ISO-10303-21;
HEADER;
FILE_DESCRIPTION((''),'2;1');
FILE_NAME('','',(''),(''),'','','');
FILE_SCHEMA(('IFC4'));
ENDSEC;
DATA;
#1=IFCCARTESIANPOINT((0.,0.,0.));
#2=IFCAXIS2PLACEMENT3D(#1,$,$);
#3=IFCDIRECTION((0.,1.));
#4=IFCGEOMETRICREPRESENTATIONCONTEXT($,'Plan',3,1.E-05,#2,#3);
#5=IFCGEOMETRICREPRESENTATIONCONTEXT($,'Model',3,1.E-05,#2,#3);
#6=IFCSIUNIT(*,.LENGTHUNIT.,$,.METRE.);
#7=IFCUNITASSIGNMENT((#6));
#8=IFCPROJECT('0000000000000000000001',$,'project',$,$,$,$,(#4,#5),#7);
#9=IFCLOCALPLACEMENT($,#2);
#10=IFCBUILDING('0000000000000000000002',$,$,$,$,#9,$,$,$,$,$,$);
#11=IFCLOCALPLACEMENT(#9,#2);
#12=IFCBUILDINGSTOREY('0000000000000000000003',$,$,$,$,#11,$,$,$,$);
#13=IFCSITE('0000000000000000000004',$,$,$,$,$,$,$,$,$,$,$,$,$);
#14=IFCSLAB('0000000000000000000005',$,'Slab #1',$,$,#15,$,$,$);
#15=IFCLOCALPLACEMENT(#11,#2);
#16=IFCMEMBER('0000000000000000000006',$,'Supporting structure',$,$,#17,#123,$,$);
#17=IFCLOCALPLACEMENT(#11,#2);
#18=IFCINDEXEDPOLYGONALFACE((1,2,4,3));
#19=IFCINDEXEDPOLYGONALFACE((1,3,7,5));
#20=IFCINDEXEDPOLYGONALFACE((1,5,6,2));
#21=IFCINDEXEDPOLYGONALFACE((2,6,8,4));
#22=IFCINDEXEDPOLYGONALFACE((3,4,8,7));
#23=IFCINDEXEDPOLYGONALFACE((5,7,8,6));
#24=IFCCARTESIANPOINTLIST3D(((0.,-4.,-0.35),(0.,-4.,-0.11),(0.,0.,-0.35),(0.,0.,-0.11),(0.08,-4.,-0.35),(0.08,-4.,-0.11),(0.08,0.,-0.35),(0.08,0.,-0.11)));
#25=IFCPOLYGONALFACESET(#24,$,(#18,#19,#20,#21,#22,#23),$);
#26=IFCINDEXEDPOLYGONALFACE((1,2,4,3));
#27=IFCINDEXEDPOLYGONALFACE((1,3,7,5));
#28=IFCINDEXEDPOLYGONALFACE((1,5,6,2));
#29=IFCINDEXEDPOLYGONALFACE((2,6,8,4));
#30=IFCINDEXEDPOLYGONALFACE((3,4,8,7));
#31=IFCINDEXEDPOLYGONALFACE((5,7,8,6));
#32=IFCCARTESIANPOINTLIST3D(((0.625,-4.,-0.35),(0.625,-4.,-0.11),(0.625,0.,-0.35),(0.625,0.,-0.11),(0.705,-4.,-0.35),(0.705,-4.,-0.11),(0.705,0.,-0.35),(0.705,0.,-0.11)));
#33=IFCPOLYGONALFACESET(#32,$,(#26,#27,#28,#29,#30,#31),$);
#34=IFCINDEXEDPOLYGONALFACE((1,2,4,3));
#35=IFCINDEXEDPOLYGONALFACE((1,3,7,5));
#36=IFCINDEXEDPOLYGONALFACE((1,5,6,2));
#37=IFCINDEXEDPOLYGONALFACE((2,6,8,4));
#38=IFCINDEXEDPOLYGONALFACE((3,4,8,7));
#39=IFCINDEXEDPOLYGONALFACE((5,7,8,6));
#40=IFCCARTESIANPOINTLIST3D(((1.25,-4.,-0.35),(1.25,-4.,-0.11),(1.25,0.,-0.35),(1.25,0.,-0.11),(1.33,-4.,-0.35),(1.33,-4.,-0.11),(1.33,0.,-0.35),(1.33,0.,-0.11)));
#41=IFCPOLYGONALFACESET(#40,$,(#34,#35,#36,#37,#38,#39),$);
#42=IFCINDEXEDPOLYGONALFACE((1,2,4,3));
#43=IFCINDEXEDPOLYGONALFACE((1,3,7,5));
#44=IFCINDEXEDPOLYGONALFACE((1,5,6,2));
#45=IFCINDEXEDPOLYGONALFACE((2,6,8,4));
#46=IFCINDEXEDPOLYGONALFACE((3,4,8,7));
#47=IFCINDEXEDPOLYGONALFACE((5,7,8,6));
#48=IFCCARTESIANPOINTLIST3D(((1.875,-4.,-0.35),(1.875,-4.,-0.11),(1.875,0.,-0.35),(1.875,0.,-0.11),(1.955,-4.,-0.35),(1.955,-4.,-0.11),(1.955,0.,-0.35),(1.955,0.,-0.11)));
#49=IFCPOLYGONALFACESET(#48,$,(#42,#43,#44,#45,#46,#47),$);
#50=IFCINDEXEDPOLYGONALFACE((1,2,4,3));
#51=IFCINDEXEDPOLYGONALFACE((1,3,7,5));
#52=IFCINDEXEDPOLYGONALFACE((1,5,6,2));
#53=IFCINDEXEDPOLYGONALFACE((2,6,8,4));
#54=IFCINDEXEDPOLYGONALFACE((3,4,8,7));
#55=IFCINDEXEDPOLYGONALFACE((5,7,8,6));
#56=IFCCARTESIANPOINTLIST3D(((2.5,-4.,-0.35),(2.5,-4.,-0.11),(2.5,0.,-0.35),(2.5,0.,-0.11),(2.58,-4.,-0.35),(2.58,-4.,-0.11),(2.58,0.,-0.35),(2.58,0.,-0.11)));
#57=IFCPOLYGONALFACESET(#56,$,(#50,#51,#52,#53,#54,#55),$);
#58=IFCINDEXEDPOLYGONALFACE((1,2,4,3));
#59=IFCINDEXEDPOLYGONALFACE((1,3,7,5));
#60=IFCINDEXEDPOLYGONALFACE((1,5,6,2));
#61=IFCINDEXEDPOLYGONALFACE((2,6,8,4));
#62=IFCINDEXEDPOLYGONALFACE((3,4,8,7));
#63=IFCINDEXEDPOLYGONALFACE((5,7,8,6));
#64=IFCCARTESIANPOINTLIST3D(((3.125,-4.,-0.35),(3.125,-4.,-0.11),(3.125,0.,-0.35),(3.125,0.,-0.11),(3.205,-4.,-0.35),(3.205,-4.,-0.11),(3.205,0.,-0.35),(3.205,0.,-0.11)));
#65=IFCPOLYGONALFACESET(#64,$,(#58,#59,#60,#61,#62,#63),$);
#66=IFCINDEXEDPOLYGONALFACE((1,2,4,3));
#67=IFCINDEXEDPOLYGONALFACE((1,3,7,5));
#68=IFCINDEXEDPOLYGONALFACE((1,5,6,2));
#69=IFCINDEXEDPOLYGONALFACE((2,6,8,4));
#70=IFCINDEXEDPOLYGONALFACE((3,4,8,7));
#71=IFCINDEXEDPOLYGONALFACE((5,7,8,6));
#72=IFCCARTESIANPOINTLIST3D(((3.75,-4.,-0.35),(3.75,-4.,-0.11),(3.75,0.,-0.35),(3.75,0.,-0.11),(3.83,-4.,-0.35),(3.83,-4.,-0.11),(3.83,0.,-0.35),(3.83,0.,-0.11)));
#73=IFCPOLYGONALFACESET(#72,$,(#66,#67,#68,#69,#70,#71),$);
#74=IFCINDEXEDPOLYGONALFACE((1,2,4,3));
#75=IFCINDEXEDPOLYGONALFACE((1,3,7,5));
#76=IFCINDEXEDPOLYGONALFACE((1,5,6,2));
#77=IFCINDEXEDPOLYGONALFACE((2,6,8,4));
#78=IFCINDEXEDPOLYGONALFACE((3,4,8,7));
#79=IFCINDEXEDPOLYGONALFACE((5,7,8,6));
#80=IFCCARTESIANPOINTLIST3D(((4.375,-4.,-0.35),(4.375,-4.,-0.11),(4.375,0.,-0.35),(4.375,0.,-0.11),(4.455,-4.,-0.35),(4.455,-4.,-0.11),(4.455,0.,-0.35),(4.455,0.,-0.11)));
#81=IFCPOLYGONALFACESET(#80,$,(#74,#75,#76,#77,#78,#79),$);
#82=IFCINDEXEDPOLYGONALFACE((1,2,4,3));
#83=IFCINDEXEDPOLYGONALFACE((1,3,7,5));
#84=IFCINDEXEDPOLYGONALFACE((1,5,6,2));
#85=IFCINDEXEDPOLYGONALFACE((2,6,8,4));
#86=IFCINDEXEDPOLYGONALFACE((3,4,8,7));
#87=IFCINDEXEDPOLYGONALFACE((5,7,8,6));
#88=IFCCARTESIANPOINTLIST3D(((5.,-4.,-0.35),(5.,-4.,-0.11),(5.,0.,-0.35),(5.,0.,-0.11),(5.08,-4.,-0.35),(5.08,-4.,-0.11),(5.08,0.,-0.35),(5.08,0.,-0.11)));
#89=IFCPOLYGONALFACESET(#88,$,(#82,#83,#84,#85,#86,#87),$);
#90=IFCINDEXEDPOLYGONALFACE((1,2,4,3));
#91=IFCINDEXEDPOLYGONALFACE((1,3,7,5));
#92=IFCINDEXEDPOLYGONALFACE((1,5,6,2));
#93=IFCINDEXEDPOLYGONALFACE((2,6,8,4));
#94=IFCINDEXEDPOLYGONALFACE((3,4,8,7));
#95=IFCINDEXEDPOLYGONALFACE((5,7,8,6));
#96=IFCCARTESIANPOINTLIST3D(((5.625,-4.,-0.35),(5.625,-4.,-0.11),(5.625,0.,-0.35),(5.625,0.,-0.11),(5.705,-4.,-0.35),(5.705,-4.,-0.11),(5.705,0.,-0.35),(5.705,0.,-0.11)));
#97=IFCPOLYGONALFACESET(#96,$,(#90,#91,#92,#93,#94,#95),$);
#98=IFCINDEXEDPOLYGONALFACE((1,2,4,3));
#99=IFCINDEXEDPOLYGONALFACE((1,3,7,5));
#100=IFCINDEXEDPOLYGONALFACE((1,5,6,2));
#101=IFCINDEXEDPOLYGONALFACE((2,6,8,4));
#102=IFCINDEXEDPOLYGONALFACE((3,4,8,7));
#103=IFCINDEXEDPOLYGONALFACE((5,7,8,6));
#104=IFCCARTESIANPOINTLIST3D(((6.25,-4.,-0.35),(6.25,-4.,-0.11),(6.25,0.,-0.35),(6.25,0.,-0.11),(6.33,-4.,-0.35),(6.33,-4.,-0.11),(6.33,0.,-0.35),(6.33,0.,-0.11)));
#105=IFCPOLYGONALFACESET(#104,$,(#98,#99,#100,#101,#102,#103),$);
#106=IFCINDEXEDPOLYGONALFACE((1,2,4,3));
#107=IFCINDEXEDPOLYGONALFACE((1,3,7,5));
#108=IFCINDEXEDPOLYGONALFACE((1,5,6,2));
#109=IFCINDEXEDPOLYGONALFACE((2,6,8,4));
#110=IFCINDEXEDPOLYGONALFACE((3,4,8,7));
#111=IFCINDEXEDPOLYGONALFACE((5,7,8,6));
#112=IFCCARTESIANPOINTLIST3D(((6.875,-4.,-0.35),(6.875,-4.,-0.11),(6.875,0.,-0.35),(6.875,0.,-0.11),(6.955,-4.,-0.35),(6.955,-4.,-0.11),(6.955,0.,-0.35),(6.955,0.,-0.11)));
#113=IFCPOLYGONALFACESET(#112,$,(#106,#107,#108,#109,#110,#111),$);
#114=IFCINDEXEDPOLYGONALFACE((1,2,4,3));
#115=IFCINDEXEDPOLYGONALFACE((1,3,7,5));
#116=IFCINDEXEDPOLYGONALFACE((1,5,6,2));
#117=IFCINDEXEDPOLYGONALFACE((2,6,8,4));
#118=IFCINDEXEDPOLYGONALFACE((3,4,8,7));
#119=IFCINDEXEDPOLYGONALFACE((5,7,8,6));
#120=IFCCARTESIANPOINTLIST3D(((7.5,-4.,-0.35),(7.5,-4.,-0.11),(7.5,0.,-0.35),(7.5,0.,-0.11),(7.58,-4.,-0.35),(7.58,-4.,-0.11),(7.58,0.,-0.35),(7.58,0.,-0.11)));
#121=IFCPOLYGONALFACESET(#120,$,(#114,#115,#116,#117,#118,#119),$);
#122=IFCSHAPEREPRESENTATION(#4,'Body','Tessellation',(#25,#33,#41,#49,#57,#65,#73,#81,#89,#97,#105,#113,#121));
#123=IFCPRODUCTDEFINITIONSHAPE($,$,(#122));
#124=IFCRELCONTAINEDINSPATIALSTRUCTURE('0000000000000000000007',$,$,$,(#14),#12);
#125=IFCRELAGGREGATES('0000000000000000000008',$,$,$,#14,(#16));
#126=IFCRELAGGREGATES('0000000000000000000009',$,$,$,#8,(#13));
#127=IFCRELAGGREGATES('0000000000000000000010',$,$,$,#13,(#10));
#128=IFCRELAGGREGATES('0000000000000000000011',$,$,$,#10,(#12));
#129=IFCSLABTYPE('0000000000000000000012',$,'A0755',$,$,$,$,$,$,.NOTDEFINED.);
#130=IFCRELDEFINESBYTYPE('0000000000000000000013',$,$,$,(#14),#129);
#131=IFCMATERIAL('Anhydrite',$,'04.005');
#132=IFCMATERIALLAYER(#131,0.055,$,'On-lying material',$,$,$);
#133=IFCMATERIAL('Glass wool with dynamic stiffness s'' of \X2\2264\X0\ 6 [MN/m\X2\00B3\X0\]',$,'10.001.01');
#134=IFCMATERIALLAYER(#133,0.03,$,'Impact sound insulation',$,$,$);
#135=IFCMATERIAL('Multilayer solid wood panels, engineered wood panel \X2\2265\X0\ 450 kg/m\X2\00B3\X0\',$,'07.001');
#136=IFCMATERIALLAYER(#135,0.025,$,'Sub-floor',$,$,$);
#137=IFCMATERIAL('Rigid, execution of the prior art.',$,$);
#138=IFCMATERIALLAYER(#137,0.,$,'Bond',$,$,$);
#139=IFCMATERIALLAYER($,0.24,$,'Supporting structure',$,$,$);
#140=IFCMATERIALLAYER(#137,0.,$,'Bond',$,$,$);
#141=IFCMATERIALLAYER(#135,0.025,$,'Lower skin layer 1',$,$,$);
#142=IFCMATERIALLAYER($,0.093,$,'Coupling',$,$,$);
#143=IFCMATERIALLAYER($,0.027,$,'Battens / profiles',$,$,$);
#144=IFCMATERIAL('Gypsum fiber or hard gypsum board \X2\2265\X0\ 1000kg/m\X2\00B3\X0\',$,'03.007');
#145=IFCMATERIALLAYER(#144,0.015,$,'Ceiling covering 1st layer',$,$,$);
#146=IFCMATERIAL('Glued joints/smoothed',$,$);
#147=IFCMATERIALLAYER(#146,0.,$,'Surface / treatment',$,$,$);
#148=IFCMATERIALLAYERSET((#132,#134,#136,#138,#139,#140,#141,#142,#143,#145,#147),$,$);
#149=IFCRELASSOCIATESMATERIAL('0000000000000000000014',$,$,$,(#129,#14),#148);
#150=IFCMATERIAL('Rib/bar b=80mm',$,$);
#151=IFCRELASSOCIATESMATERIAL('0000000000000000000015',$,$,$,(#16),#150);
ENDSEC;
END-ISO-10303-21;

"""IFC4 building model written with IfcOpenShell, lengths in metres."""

from ifc_helpers import new_model, si_unit, direction, frame, frame_2d, origin, place, context, project, spatial, rectangle, extrude, material, layer, layer_set, type_object, element, aggregate, save


model = new_model("IFC4")

# Units and contexts
plan_context = context("Plan", 3, precision=1e-05, world=origin(), true_north=direction((0.0, 1.0)))
model_context = context("Model", 3, precision=1e-05, world=origin(), true_north=direction((0.0, 1.0)))
ifc_project = project(units=[si_unit("LENGTHUNIT", "METRE")], contexts=[plan_context, model_context])

# Site, building, storey
site = spatial("IfcSite", under=ifc_project)
building_placement = place(None, origin())
building = spatial("IfcBuilding", under=site, at=building_placement)
storey_placement = place(building_placement, origin())
storey = spatial("IfcBuildingStorey", under=building, at=storey_placement)

# Slab, member
ifc_material_1 = material(Name="Anhydrite", Category="04.005")
ifc_layer_1 = layer(ifc_material_1, 0.055, Name="On-lying material")
ifc_material_2 = material(Name="Glass wool with dynamic stiffness s' of ≤ 6 [MN/m³]", Category="10.001.01")
ifc_layer_2 = layer(ifc_material_2, 0.03, Name="Impact sound insulation")
ifc_material_3 = material(Name="Multilayer solid wood panels, engineered wood panel ≥ 450 kg/m³", Category="07.001")
ifc_layer_3 = layer(ifc_material_3, 0.025, Name="Sub-floor")
ifc_material_4 = material(Name="Rigid, execution of the prior art.")
ifc_layer_4 = layer(ifc_material_4, 0.0, Name="Bond")
ifc_layer_5 = layer(None, 0.24, Name="Supporting structure")
ifc_layer_6 = layer(ifc_material_4, 0.0, Name="Bond")
ifc_layer_7 = layer(ifc_material_3, 0.025, Name="Lower skin layer 1")
ifc_layer_8 = layer(None, 0.093, Name="Coupling")
ifc_layer_9 = layer(None, 0.027, Name="Battens / profiles")
ifc_material_5 = material(Name="Gypsum fiber or hard gypsum board ≥ 1000kg/m³", Category="03.007")
ifc_layer_10 = layer(ifc_material_5, 0.015, Name="Ceiling covering 1st layer")
ifc_material_6 = material(Name="Glued joints/smoothed")
ifc_layer_11 = layer(ifc_material_6, 0.0, Name="Surface / treatment")
ifc_layer_set = layer_set([ifc_layer_1, ifc_layer_2, ifc_layer_3, ifc_layer_4, ifc_layer_5, ifc_layer_6, ifc_layer_7, ifc_layer_8, ifc_layer_9, ifc_layer_10, ifc_layer_11])
slab_type = type_object("IfcSlabType", Name="A0755", PredefinedType="NOTDEFINED", material=ifc_layer_set)
slab_placement = place(None, frame((0.0, 0.0, 0.0), z_axis=(0.0, 0.0, -1.0), x_axis=(1.0, 0.0, 0.0)))
slab = element("IfcSlab", 1, at=slab_placement, inside=storey, type_object=slab_type, material=ifc_layer_set, Name="Slab #1")
ifc_material_7 = material(Name="Rib/bar b=80mm")
member_1_placement = place(slab_placement, origin())
member_1 = element("IfcMember", 2, at=member_1_placement, material=ifc_material_7, Name="Supporting structure", context=plan_context, shape_type="SweptSolid", body=[
    extrude(rectangle(XDim=0.08, YDim=0.24, at=frame_2d((0.04, 0.12), x_axis=(1.0, 0.0))), frame((0.0, 4.0, 0.11), z_axis=(0.0, -1.0, 0.0), x_axis=(1.0, 0.0, 0.0)), (0.0, 0.0, 1.0), 4.0),
    extrude(rectangle(XDim=0.08, YDim=0.24, at=frame_2d((0.04, 0.12), x_axis=(1.0, 0.0))), frame((0.625, 4.0, 0.11), z_axis=(0.0, -1.0, 0.0), x_axis=(1.0, 0.0, 0.0)), (0.0, 0.0, 1.0), 4.0),
    extrude(rectangle(XDim=0.08, YDim=0.24, at=frame_2d((0.04, 0.12), x_axis=(1.0, 0.0))), frame((1.25, 4.0, 0.11), z_axis=(0.0, -1.0, 0.0), x_axis=(1.0, 0.0, 0.0)), (0.0, 0.0, 1.0), 4.0),
    extrude(rectangle(XDim=0.08, YDim=0.24, at=frame_2d((0.04, 0.12), x_axis=(1.0, 0.0))), frame((1.875, 4.0, 0.11), z_axis=(0.0, -1.0, 0.0), x_axis=(1.0, 0.0, 0.0)), (0.0, 0.0, 1.0), 4.0),
    extrude(rectangle(XDim=0.08, YDim=0.24, at=frame_2d((0.04, 0.12), x_axis=(1.0, 0.0))), frame((2.5, 4.0, 0.11), z_axis=(0.0, -1.0, 0.0), x_axis=(1.0, 0.0, 0.0)), (0.0, 0.0, 1.0), 4.0),
    extrude(rectangle(XDim=0.08, YDim=0.24, at=frame_2d((0.04, 0.12), x_axis=(1.0, 0.0))), frame((3.125, 4.0, 0.11), z_axis=(0.0, -1.0, 0.0), x_axis=(1.0, 0.0, 0.0)), (0.0, 0.0, 1.0), 4.0),
    extrude(rectangle(XDim=0.08, YDim=0.24, at=frame_2d((0.04, 0.12), x_axis=(1.0, 0.0))), frame((3.75, 4.0, 0.11), z_axis=(0.0, -1.0, 0.0), x_axis=(1.0, 0.0, 0.0)), (0.0, 0.0, 1.0), 4.0),
    extrude(rectangle(XDim=0.08, YDim=0.24, at=frame_2d((0.04, 0.12), x_axis=(1.0, 0.0))), frame((4.375, 4.0, 0.11), z_axis=(0.0, -1.0, 0.0), x_axis=(1.0, 0.0, 0.0)), (0.0, 0.0, 1.0), 4.0),
    extrude(rectangle(XDim=0.08, YDim=0.24, at=frame_2d((0.04, 0.12), x_axis=(1.0, 0.0))), frame((5.0, 4.0, 0.11), z_axis=(0.0, -1.0, 0.0), x_axis=(1.0, 0.0, 0.0)), (0.0, 0.0, 1.0), 4.0),
    extrude(rectangle(XDim=0.08, YDim=0.24, at=frame_2d((0.04, 0.12), x_axis=(1.0, 0.0))), frame((5.625, 4.0, 0.11), z_axis=(0.0, -1.0, 0.0), x_axis=(1.0, 0.0, 0.0)), (0.0, 0.0, 1.0), 4.0),
    extrude(rectangle(XDim=0.08, YDim=0.24, at=frame_2d((0.04, 0.12), x_axis=(1.0, 0.0))), frame((6.25, 4.0, 0.11), z_axis=(0.0, -1.0, 0.0), x_axis=(1.0, 0.0, 0.0)), (0.0, 0.0, 1.0), 4.0),
    extrude(rectangle(XDim=0.08, YDim=0.24, at=frame_2d((0.04, 0.12), x_axis=(1.0, 0.0))), frame((6.875, 4.0, 0.11), z_axis=(0.0, -1.0, 0.0), x_axis=(1.0, 0.0, 0.0)), (0.0, 0.0, 1.0), 4.0),
    extrude(rectangle(XDim=0.08, YDim=0.24, at=frame_2d((0.04, 0.12), x_axis=(1.0, 0.0))), frame((7.5, 4.0, 0.11), z_axis=(0.0, -1.0, 0.0), x_axis=(1.0, 0.0, 0.0)), (0.0, 0.0, 1.0), 4.0),
])
aggregate(slab, [member_1])

save(model, "model.ifc")
